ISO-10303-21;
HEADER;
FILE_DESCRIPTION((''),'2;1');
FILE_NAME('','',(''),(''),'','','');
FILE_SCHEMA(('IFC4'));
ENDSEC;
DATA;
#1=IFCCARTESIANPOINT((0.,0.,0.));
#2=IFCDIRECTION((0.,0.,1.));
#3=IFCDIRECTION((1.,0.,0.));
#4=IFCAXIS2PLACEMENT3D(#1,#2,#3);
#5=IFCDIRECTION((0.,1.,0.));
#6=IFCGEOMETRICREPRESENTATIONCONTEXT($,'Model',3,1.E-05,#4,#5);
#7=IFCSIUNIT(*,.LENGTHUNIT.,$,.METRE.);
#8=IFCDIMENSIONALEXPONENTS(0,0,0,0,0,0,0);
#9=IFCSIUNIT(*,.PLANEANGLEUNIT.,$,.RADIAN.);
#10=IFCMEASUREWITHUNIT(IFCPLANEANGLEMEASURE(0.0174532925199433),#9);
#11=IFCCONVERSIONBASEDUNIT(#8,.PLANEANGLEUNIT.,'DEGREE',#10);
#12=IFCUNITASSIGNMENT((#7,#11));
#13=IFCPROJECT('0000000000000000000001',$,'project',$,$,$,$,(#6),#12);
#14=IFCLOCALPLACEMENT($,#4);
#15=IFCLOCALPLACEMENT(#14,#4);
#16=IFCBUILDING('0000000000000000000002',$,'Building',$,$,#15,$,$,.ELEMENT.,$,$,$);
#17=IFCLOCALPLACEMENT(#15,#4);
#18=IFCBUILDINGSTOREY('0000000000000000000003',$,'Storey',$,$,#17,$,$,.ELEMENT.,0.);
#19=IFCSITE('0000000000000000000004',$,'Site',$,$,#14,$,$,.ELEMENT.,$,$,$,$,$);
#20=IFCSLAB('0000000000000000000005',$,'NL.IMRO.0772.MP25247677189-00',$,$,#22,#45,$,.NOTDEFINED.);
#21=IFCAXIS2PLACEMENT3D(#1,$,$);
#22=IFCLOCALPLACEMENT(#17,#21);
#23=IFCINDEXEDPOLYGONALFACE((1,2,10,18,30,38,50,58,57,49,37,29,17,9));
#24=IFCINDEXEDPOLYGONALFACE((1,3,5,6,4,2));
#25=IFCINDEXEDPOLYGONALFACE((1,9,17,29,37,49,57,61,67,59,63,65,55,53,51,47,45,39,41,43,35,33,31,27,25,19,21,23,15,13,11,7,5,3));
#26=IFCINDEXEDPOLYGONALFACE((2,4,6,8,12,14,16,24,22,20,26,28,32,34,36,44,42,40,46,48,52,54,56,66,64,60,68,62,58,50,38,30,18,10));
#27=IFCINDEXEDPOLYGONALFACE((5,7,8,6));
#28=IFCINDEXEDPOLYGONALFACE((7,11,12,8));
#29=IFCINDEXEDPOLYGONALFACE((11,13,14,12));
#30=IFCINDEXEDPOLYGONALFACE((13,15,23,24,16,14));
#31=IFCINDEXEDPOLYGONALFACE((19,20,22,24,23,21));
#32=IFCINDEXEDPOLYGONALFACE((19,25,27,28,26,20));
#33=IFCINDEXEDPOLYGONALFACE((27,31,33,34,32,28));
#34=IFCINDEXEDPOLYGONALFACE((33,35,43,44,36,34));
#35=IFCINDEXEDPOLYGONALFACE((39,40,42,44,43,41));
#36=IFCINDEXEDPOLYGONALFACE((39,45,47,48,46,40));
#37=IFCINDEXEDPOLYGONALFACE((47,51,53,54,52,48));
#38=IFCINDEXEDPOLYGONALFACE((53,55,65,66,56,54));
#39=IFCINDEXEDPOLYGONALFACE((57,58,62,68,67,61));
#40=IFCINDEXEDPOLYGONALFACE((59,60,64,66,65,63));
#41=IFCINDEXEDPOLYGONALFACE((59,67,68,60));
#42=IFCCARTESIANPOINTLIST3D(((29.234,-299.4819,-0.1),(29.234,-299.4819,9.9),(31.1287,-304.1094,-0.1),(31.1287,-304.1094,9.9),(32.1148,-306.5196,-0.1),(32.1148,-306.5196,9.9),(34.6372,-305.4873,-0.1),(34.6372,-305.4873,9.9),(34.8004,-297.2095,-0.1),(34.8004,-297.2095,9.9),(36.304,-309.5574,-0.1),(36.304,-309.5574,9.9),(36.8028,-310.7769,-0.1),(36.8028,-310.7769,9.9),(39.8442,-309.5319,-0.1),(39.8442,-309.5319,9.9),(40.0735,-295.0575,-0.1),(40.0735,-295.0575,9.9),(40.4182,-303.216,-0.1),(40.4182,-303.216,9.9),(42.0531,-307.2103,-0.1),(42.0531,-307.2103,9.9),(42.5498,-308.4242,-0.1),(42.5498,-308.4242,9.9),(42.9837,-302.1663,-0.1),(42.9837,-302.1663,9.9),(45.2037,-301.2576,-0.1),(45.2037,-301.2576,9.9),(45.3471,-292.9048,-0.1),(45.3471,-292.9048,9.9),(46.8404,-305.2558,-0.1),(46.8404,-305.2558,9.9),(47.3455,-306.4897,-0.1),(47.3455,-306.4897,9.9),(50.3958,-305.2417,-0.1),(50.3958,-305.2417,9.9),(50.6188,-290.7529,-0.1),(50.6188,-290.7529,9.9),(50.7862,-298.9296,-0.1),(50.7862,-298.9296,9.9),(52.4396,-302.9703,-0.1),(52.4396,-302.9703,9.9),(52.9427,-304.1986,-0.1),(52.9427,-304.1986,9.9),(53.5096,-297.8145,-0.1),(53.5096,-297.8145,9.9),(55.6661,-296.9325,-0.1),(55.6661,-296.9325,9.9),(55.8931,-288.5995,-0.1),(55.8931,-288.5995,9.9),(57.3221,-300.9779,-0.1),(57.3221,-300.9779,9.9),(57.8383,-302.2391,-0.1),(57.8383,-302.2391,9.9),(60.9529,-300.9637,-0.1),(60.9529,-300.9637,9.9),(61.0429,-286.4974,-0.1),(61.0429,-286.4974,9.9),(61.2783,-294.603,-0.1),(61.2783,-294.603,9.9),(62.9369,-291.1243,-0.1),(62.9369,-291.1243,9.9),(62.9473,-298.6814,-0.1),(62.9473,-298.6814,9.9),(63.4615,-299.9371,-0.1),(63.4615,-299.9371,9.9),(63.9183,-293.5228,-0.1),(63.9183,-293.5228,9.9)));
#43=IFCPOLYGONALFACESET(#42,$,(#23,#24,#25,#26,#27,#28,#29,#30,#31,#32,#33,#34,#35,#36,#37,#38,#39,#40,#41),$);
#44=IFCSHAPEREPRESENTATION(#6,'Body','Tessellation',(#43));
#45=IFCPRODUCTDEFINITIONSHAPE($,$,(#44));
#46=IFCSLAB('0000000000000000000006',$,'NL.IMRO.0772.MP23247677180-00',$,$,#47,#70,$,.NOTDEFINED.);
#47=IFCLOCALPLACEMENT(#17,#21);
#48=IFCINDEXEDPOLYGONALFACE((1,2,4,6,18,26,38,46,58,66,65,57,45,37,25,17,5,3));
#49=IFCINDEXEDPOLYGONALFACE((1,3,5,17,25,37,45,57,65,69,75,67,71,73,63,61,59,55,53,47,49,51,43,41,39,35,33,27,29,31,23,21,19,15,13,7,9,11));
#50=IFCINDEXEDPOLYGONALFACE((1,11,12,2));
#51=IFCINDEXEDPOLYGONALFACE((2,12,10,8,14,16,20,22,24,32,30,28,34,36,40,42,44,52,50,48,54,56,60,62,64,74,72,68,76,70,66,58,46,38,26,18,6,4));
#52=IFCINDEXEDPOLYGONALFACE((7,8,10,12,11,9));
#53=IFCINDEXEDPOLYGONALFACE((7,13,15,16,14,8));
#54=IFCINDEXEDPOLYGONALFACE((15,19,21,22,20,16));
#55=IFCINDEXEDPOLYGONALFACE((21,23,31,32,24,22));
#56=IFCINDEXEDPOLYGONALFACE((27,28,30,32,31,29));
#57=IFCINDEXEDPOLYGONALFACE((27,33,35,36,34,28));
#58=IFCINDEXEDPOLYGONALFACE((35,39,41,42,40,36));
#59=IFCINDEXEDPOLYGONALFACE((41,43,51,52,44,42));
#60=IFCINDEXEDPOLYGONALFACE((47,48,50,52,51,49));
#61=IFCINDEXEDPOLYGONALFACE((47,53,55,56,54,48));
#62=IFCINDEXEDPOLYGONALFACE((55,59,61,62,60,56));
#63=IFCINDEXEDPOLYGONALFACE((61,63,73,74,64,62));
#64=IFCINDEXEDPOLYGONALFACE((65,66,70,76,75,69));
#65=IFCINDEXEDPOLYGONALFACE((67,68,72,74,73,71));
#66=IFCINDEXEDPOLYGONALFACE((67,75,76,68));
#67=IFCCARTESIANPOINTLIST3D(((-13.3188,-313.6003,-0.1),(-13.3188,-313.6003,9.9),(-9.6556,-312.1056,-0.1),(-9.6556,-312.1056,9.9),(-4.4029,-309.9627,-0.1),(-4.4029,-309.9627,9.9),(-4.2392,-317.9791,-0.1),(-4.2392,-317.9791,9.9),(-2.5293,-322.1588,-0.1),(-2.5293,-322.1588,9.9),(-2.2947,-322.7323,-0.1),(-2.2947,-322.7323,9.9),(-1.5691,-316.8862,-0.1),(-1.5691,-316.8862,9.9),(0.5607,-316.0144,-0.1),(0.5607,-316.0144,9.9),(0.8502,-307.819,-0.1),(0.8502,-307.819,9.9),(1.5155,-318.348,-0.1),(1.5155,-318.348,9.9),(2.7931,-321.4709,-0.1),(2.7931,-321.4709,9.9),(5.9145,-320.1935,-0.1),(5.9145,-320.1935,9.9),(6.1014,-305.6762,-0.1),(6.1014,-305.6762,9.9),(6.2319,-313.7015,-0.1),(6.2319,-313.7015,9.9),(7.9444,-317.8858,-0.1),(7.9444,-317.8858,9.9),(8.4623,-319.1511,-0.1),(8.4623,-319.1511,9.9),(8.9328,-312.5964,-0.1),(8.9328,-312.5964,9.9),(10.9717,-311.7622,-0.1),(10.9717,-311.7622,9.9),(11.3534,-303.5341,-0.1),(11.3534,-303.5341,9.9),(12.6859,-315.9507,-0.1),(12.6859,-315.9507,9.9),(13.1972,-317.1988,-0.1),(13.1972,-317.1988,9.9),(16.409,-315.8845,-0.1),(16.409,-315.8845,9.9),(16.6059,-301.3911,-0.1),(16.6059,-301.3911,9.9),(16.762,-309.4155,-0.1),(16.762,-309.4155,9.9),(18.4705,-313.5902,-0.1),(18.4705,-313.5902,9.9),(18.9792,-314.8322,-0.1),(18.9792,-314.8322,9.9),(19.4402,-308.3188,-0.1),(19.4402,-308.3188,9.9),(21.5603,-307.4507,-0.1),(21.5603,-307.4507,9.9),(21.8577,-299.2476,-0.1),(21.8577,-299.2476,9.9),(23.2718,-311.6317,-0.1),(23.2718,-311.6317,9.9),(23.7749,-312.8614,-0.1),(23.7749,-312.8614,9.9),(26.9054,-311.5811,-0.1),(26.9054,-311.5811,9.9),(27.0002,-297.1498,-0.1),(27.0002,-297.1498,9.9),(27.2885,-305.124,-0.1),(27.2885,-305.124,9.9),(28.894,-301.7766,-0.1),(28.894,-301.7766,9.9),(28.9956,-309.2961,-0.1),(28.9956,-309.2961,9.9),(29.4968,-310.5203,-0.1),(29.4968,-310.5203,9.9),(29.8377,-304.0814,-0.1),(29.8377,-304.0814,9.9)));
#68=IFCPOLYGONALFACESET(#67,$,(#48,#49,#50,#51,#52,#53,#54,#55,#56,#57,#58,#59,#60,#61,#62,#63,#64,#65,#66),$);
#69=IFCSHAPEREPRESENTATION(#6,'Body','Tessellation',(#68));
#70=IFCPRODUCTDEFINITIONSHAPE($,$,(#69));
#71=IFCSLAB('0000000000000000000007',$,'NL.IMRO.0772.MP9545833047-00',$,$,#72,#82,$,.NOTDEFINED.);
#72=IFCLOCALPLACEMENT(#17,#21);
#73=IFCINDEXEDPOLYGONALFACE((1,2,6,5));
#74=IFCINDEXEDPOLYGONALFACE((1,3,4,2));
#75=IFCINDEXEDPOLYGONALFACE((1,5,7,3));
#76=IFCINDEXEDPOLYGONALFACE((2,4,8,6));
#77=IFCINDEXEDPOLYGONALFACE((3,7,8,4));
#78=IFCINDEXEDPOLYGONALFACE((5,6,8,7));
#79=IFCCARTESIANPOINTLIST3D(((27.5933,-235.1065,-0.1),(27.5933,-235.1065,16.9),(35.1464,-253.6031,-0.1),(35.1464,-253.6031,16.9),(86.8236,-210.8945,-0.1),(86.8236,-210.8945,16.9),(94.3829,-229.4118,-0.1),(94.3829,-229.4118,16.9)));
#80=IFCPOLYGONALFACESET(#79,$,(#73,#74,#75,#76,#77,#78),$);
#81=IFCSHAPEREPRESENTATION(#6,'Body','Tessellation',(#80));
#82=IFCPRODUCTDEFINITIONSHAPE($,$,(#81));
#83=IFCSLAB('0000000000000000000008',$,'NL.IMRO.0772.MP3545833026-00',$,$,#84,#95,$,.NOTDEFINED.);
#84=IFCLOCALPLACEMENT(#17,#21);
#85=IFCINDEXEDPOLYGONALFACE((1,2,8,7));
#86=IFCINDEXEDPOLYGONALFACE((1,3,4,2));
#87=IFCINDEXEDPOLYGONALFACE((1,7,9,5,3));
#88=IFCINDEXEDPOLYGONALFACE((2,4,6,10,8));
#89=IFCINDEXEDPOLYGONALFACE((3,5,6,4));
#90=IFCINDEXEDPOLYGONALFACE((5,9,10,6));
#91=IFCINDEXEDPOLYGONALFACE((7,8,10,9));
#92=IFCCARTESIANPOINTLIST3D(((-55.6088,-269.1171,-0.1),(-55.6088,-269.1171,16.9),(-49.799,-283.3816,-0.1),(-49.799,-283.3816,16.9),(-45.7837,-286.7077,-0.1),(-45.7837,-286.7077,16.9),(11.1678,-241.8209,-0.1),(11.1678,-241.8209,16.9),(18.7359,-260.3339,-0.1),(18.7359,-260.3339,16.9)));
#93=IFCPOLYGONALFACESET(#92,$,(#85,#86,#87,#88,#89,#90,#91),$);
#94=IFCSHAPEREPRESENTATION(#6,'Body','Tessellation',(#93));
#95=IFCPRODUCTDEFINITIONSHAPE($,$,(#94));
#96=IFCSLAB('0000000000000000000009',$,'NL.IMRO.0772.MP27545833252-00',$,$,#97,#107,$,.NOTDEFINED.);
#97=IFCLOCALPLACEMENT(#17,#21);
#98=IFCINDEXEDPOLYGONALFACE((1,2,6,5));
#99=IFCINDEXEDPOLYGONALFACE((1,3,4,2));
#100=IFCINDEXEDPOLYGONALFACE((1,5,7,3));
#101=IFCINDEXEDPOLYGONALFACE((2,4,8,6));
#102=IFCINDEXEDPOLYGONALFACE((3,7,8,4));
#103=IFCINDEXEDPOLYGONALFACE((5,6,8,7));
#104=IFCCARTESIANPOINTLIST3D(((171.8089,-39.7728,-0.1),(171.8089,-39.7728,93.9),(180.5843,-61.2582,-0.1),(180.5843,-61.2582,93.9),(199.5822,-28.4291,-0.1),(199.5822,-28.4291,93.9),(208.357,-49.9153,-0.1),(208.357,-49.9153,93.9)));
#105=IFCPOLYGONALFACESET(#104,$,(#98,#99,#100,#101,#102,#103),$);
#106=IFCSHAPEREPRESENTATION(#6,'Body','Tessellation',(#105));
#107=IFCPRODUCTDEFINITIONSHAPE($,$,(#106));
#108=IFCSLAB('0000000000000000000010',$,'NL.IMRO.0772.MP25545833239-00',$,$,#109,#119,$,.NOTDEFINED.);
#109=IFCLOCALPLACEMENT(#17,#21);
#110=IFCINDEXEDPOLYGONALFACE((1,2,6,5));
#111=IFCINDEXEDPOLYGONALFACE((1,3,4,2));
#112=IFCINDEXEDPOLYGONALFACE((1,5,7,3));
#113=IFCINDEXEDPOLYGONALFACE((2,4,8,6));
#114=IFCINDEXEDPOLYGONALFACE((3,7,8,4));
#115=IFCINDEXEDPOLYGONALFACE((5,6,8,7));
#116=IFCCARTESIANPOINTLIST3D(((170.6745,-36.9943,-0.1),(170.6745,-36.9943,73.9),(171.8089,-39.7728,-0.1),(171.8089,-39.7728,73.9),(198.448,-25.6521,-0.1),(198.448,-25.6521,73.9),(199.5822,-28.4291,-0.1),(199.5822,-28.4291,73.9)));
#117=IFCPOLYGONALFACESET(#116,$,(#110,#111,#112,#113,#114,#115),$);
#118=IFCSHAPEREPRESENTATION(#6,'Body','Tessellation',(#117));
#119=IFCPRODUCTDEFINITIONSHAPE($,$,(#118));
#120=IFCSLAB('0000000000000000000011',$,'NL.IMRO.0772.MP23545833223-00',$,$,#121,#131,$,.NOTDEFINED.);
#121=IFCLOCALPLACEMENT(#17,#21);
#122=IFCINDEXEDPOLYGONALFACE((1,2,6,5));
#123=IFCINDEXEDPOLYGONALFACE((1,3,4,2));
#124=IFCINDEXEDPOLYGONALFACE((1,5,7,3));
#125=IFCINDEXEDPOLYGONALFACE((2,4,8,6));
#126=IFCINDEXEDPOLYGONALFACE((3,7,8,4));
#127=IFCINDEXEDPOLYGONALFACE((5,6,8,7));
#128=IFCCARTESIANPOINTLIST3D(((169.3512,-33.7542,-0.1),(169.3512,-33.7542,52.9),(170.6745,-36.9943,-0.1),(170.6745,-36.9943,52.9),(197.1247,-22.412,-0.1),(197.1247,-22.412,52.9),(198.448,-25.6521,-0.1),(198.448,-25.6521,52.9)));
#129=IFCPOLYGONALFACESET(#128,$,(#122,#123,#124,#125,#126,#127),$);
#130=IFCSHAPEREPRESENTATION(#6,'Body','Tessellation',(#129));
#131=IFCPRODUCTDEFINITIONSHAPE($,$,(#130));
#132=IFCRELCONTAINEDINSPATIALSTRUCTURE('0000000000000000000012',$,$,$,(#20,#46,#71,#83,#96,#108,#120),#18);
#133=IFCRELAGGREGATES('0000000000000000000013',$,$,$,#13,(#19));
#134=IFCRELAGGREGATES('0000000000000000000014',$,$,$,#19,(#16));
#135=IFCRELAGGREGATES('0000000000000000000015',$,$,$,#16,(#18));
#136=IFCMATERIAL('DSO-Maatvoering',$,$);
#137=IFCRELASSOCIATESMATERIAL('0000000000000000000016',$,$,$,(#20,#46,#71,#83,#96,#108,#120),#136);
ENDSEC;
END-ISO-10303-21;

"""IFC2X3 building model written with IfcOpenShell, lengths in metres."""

from ifc_helpers import new_model, entity, si_unit, converted_unit, direction, frame, origin_with_axes, place, context, project, spatial, polyline, outline, extrude, material, element, save


model = new_model("IFC2X3")

# Units and contexts
model_context = context("Model", 3, precision=1e-05, world=origin_with_axes(), true_north=direction((0.0, 1.0, 0.0)))
ifc_project = project(units=[si_unit("LENGTHUNIT", "METRE"), converted_unit("PLANEANGLEUNIT", "DEGREE", entity("IfcPlaneAngleMeasure", 0.0174532925199433), si_unit("PLANEANGLEUNIT", "RADIAN"), dimensions=[0, 0, 0, 0, 0, 0, 0])], contexts=[model_context])

# Site, building, storey
site_placement = place(None, origin_with_axes())
site = spatial("IfcSite", under=ifc_project, at=site_placement, Name="Site", CompositionType="ELEMENT")
building_placement = place(site_placement, origin_with_axes())
building = spatial("IfcBuilding", under=site, at=building_placement, Name="Building", CompositionType="ELEMENT")
storey_placement = place(building_placement, origin_with_axes())
storey = spatial("IfcBuildingStorey", under=building, at=storey_placement, Name="Storey", CompositionType="ELEMENT", Elevation=0.0)

# Slabs
ifc_material = material(Name="DSO-Maatvoering")
slab_1_placement = place(storey_placement, frame((0.0, 0.0, -0.1), z_axis=(0.0, 0.0, 1.0), x_axis=(1.0, 0.0, 0.0)))
element("IfcSlab", 1, at=slab_1_placement, inside=storey, material=ifc_material, Name="NL.IMRO.0772.MP25247677189-00", PredefinedType="NOTDEFINED", context=model_context, shape_type="SweptSolid", body=[
    extrude(outline(polyline([(61.2783, -294.603), (62.9473, -298.6814), (63.4615, -299.9371), (60.9529, -300.9637), (57.8383, -302.2391), (57.3221, -300.9779), (55.6661, -296.9325), (53.5096, -297.8145), (50.7862, -298.9296), (52.4396, -302.9703), (52.9427, -304.1986), (50.3958, -305.2417), (47.3455, -306.4897), (46.8404, -305.2558), (45.2037, -301.2576), (42.9837, -302.1663), (40.4182, -303.216), (42.0531, -307.2103), (42.5498, -308.4242), (39.8442, -309.5319), (36.8028, -310.7769), (36.304, -309.5574), (34.6372, -305.4873), (32.1148, -306.5196), (31.1287, -304.1094), (29.234, -299.4819), (34.8004, -297.2095), (40.0735, -295.0575), (45.3471, -292.9048), (50.6188, -290.7529), (55.8931, -288.5995), (61.0429, -286.4974), (62.9369, -291.1243), (63.9183, -293.5228), (61.2783, -294.603)])), origin_with_axes(), (0.0, 0.0, 1.0), 10.0),
])
slab_2_placement = place(storey_placement, frame((0.0, 0.0, -0.1), z_axis=(0.0, 0.0, 1.0), x_axis=(1.0, 0.0, 0.0)))
element("IfcSlab", 2, at=slab_2_placement, inside=storey, material=ifc_material, Name="NL.IMRO.0772.MP23247677180-00", PredefinedType="NOTDEFINED", context=model_context, shape_type="SweptSolid", body=[
    extrude(outline(polyline([(-9.6556, -312.1056), (-4.4029, -309.9627), (0.8502, -307.819), (6.1014, -305.6762), (11.3534, -303.5341), (16.6059, -301.3911), (21.8577, -299.2476), (27.0002, -297.1498), (28.894, -301.7766), (29.8377, -304.0814), (27.2885, -305.124), (28.9956, -309.2961), (29.4968, -310.5203), (26.9054, -311.5811), (23.7749, -312.8614), (23.2718, -311.6317), (21.5603, -307.4507), (19.4402, -308.3188), (16.762, -309.4155), (18.4705, -313.5902), (18.9792, -314.8322), (16.409, -315.8845), (13.1972, -317.1988), (12.6859, -315.9507), (10.9717, -311.7622), (8.9328, -312.5964), (6.2319, -313.7015), (7.9444, -317.8858), (8.4623, -319.1511), (5.9145, -320.1935), (2.7931, -321.4709), (1.5155, -318.348), (0.5607, -316.0144), (-1.5691, -316.8862), (-4.2392, -317.9791), (-2.5293, -322.1588), (-2.2947, -322.7323), (-13.3188, -313.6003), (-9.6556, -312.1056)])), origin_with_axes(), (0.0, 0.0, 1.0), 10.0),
])
for number, where, z_axis, x_axis, name in (
    (3, (0.0, 0.0, -0.1), (0.0, 0.0, 1.0), (1.0, 0.0, 0.0), "NL.IMRO.0772.MP9545833047-00"),
):
    element("IfcSlab", number, at=place(storey_placement, frame(where, z_axis=z_axis, x_axis=x_axis)), inside=storey, material=ifc_material, Name=name, PredefinedType="NOTDEFINED", context=model_context, shape_type="SweptSolid", body=[
        extrude(outline(polyline([(86.8236, -210.8945), (94.3829, -229.4118), (35.1464, -253.6031), (27.5933, -235.1065), (86.8236, -210.8945)])), origin_with_axes(), (0.0, 0.0, 1.0), 17.0),
    ])
for number, where, z_axis, x_axis, name in (
    (4, (0.0, 0.0, -0.1), (0.0, 0.0, 1.0), (1.0, 0.0, 0.0), "NL.IMRO.0772.MP3545833026-00"),
):
    element("IfcSlab", number, at=place(storey_placement, frame(where, z_axis=z_axis, x_axis=x_axis)), inside=storey, material=ifc_material, Name=name, PredefinedType="NOTDEFINED", context=model_context, shape_type="SweptSolid", body=[
        extrude(outline(polyline([(-55.6088, -269.1171), (11.1678, -241.8209), (18.7359, -260.3339), (-45.7837, -286.7077), (-49.799, -283.3816), (-55.6088, -269.1171)])), origin_with_axes(), (0.0, 0.0, 1.0), 17.0),
    ])
for number, where, z_axis, x_axis, name in (
    (5, (0.0, 0.0, -0.1), (0.0, 0.0, 1.0), (1.0, 0.0, 0.0), "NL.IMRO.0772.MP27545833252-00"),
):
    element("IfcSlab", number, at=place(storey_placement, frame(where, z_axis=z_axis, x_axis=x_axis)), inside=storey, material=ifc_material, Name=name, PredefinedType="NOTDEFINED", context=model_context, shape_type="SweptSolid", body=[
        extrude(outline(polyline([(199.5822, -28.4291), (208.357, -49.9153), (180.5843, -61.2582), (171.8089, -39.7728), (199.5822, -28.4291)])), origin_with_axes(), (0.0, 0.0, 1.0), 94.0),
    ])
for number, where, z_axis, x_axis, name in (
    (6, (0.0, 0.0, -0.1), (0.0, 0.0, 1.0), (1.0, 0.0, 0.0), "NL.IMRO.0772.MP25545833239-00"),
):
    element("IfcSlab", number, at=place(storey_placement, frame(where, z_axis=z_axis, x_axis=x_axis)), inside=storey, material=ifc_material, Name=name, PredefinedType="NOTDEFINED", context=model_context, shape_type="SweptSolid", body=[
        extrude(outline(polyline([(199.5822, -28.4291), (171.8089, -39.7728), (170.6745, -36.9943), (198.448, -25.6521), (199.5822, -28.4291)])), origin_with_axes(), (0.0, 0.0, 1.0), 74.0),
    ])
for number, where, z_axis, x_axis, name in (
    (7, (0.0, 0.0, -0.1), (0.0, 0.0, 1.0), (1.0, 0.0, 0.0), "NL.IMRO.0772.MP23545833223-00"),
):
    element("IfcSlab", number, at=place(storey_placement, frame(where, z_axis=z_axis, x_axis=x_axis)), inside=storey, material=ifc_material, Name=name, PredefinedType="NOTDEFINED", context=model_context, shape_type="SweptSolid", body=[
        extrude(outline(polyline([(169.3512, -33.7542), (197.1247, -22.412), (198.448, -25.6521), (170.6745, -36.9943), (169.3512, -33.7542)])), origin_with_axes(), (0.0, 0.0, 1.0), 53.0),
    ])

save(model, "model.ifc")
